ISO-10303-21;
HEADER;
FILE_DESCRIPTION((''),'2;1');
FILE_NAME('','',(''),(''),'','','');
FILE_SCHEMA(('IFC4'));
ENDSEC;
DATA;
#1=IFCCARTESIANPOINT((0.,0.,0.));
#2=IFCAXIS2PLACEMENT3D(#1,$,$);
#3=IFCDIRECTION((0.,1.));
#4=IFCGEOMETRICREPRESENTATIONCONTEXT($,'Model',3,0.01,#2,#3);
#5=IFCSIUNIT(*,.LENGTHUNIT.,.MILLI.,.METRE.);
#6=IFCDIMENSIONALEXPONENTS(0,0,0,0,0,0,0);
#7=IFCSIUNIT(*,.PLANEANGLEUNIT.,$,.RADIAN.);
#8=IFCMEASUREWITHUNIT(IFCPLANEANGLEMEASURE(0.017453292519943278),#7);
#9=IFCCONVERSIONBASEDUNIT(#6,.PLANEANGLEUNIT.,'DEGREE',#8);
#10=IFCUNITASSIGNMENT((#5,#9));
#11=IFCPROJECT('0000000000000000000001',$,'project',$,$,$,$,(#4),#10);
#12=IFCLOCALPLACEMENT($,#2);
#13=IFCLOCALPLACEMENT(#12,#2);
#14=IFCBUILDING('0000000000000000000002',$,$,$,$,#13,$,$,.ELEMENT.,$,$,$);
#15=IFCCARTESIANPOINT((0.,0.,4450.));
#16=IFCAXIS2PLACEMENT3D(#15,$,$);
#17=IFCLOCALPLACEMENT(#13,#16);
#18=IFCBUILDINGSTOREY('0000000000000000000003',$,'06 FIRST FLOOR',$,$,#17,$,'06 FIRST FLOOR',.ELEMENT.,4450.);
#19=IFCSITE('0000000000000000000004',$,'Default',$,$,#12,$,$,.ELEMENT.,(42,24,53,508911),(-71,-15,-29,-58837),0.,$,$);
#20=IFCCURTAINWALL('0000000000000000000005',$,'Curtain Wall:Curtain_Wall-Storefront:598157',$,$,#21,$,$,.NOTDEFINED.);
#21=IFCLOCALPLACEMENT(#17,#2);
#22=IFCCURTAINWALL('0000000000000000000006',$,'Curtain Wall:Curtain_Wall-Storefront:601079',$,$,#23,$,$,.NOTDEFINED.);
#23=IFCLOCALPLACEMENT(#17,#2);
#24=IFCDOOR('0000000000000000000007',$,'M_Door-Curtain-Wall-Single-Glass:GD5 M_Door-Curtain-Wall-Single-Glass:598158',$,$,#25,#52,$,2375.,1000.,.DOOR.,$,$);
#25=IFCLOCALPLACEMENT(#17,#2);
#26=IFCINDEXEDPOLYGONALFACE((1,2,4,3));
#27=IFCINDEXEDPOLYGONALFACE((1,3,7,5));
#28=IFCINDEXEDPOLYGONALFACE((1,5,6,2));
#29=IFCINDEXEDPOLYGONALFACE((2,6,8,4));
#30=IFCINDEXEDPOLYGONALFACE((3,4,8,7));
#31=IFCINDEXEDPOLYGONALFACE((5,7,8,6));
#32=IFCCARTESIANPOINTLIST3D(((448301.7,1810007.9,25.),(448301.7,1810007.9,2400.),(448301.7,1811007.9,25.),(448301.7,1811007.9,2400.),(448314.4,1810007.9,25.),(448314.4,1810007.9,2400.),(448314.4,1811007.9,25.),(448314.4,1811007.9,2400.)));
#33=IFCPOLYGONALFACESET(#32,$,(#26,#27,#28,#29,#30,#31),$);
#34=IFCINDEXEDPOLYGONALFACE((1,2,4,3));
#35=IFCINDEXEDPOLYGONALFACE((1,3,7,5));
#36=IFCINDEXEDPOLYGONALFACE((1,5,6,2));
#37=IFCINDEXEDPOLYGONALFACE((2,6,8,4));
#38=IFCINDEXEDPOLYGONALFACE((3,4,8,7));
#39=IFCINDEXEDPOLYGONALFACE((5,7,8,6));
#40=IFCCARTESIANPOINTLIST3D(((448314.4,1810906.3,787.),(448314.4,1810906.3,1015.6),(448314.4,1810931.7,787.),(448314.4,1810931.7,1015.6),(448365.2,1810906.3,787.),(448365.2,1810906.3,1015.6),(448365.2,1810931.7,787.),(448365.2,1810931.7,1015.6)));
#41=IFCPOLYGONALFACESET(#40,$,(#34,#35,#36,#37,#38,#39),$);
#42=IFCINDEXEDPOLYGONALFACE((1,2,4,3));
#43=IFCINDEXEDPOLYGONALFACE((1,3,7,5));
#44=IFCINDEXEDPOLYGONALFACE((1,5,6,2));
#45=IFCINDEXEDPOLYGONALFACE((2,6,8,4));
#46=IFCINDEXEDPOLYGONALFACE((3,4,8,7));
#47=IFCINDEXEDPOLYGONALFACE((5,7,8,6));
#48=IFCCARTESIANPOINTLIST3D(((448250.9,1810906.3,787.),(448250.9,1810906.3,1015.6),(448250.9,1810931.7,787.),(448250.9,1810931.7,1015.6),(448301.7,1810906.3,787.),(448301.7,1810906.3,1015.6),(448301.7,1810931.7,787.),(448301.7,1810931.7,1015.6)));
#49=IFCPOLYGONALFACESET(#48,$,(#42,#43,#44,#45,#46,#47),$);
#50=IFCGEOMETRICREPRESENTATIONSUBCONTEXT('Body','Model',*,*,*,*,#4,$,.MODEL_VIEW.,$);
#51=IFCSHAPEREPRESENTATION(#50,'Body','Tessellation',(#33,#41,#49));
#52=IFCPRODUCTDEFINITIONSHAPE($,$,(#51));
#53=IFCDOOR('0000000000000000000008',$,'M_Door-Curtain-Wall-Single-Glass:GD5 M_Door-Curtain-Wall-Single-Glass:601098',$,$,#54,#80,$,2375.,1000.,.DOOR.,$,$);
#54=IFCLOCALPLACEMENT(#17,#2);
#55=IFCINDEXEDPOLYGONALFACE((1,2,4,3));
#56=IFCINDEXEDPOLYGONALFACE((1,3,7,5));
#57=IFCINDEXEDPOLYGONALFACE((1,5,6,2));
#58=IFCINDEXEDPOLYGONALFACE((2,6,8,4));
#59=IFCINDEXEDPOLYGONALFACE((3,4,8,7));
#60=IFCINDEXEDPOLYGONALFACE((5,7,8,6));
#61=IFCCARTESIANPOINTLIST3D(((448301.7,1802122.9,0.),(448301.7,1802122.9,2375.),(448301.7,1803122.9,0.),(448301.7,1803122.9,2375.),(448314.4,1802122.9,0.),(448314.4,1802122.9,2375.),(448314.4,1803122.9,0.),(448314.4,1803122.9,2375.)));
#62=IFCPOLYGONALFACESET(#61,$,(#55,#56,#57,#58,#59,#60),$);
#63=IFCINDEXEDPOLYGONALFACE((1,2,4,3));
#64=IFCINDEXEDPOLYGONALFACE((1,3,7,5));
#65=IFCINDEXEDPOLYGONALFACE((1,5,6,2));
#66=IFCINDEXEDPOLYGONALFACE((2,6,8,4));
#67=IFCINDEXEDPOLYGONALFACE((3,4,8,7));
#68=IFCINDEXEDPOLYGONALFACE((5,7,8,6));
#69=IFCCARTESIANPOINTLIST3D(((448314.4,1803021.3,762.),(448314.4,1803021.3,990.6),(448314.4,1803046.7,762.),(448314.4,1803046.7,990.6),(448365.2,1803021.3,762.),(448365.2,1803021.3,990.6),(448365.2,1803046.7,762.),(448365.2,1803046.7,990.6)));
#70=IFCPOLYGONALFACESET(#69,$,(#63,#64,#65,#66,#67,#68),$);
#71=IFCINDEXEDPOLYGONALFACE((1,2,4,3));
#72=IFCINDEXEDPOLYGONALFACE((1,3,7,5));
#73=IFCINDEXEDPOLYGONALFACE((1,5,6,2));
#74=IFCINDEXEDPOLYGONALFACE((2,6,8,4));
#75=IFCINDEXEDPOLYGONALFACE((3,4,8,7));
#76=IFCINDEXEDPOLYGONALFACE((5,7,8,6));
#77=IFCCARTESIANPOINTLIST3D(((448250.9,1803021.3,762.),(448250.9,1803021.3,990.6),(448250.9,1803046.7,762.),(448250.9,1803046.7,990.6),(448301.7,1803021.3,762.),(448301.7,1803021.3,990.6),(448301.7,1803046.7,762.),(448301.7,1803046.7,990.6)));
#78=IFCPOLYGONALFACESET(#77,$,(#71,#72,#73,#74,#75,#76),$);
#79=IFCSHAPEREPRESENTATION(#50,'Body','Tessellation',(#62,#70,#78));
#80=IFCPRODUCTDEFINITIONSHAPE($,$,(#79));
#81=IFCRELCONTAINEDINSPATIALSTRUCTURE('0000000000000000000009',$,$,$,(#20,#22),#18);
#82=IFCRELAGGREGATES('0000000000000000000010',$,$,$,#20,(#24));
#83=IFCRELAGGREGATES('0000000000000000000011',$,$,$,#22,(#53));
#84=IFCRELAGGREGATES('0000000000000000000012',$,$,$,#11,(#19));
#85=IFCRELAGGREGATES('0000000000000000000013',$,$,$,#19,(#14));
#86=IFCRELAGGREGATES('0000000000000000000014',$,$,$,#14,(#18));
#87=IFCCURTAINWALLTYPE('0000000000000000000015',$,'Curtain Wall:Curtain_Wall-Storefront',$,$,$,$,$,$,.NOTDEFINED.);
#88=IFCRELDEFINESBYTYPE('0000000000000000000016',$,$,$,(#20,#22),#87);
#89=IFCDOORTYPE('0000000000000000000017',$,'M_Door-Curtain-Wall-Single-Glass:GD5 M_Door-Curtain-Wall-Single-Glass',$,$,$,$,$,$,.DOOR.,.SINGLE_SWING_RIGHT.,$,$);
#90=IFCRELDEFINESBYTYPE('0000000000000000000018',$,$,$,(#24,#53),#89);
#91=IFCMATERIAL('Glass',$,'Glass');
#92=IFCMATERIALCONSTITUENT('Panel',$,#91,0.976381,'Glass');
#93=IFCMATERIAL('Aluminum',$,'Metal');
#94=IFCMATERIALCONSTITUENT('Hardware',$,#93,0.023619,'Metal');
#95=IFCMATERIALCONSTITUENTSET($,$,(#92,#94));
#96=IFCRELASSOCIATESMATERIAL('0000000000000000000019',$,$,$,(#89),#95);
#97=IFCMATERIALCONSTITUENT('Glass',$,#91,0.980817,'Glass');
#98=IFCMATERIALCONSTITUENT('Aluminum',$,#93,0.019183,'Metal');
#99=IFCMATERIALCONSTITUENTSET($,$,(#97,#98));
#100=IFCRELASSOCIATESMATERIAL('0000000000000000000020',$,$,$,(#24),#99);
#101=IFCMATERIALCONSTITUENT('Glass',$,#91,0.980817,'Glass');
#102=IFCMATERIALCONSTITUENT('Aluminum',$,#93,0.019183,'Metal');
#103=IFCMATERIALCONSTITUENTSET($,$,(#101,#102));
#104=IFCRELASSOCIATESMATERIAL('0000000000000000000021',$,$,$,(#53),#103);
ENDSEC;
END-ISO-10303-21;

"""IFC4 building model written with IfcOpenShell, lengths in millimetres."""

from ifc_helpers import new_model, entity, si_unit, converted_unit, direction, frame, origin, place, context, subcontext, project, spatial, indexed_curve, outline, extrude, source, transform, mapped, material, constituent, constituent_set, type_object, type_shapes, element, aggregate, save


model = new_model("IFC4")

# Units and contexts
model_context = context("Model", 3, precision=0.01, world=origin(), true_north=direction((0.0, 1.0)))
body_context = subcontext(model_context, "Body", "Model", "MODEL_VIEW")
ifc_project = project(units=[si_unit("LENGTHUNIT", "METRE", prefix="MILLI"), converted_unit("PLANEANGLEUNIT", "DEGREE", entity("IfcPlaneAngleMeasure", 0.017453292519943278), si_unit("PLANEANGLEUNIT", "RADIAN"), dimensions=[0, 0, 0, 0, 0, 0, 0])], contexts=[model_context])

# Site, building, storey
site_placement = place(None, origin())
site = spatial("IfcSite", under=ifc_project, at=site_placement, Name="Default", CompositionType="ELEMENT", RefLatitude=(42, 24, 53, 508911), RefLongitude=(-71, -15, -29, -58837), RefElevation=0.0)
building_placement = place(site_placement, origin())
building = spatial("IfcBuilding", under=site, at=building_placement, CompositionType="ELEMENT")
storey_placement = place(building_placement, frame((0.0, 0.0, 4450.0)))
storey = spatial("IfcBuildingStorey", under=building, at=storey_placement, Name="06 FIRST FLOOR", LongName="06 FIRST FLOOR", CompositionType="ELEMENT", Elevation=4450.0)

# Curtain walls
curtain_wall_type = type_object("IfcCurtainWallType", Name="Curtain Wall:Curtain_Wall-Storefront", PredefinedType="NOTDEFINED")
curtain_wall_1_placement = place(storey_placement, frame((0.0, 0.0, -4450.0)))
curtain_wall_1 = element("IfcCurtainWall", 1, at=curtain_wall_1_placement, inside=storey, type_object=curtain_wall_type, Name="Curtain Wall:Curtain_Wall-Storefront:598157", PredefinedType="NOTDEFINED")
curtain_wall_2_placement = place(storey_placement, frame((0.0, 0.0, -4450.0)))
curtain_wall_2 = element("IfcCurtainWall", 2, at=curtain_wall_2_placement, inside=storey, type_object=curtain_wall_type, Name="Curtain Wall:Curtain_Wall-Storefront:601079", PredefinedType="NOTDEFINED")

# Shared definitions
ifc_material_1 = material(Name="Glass", Category="Glass")

# Doors
ifc_constituent_1 = constituent(ifc_material_1, Name="Glass", Category="Glass", fraction=0.980817)
ifc_material_2 = material(Name="Aluminum", Category="Metal")
ifc_constituent_2 = constituent(ifc_material_2, Name="Aluminum", Category="Metal", fraction=0.019183)
ifc_constituent_set_1 = constituent_set(constituents=[ifc_constituent_1, ifc_constituent_2])
ifc_constituent_3 = constituent(ifc_material_1, Name="Panel", Category="Glass", fraction=0.976381)
ifc_constituent_4 = constituent(ifc_material_2, Name="Hardware", Category="Metal", fraction=0.023619)
ifc_constituent_set_2 = constituent_set(constituents=[ifc_constituent_3, ifc_constituent_4])
door_type = type_object("IfcDoorType", Name="M_Door-Curtain-Wall-Single-Glass:GD5 M_Door-Curtain-Wall-Single-Glass", OperationType="SINGLE_SWING_RIGHT", PredefinedType="DOOR", material=ifc_constituent_set_2)
shared_shape_1 = source(origin(), body_context, "Body", "SweptSolid", [
    extrude(outline(indexed_curve([(-500.0, -6.4), (500.0, -6.4), (500.0, 6.4), (-500.0, 6.4), (-500.0, -6.4)], self_intersect=False)), frame((0.0, 44.5, 0.0), z_axis=(0.0, 0.0, 1.0), x_axis=(-1.0, 0.0, 0.0)), (0.0, 0.0, 1.0), 2375.0),
    extrude(outline(indexed_curve([(-25.4, -12.7), (25.4, -12.7), (25.4, 12.7), (-25.4, 12.7), (-25.4, -12.7)], self_intersect=False)), frame((-411.1, 76.2, 762.0), z_axis=(0.0, 0.0, 1.0), x_axis=(0.0, -1.0, 0.0)), (0.0, 0.0, 1.0), 228.6),
    extrude(outline(indexed_curve([(-25.4, -12.7), (25.4, -12.7), (25.4, 12.7), (-25.4, 12.7), (-25.4, -12.7)], self_intersect=False)), frame((-411.1, 12.7, 762.0), z_axis=(0.0, 0.0, 1.0), x_axis=(0.0, 1.0, 0.0)), (0.0, 0.0, 1.0), 228.6),
])
type_shapes(door_type, [shared_shape_1])
door_1_placement = place(curtain_wall_1_placement, frame((448263.6, 1810507.9, 4475.0), z_axis=(0.0, 0.0, 1.0), x_axis=(0.0, -1.0, 0.0)))
door_1 = element("IfcDoor", 3, at=door_1_placement, type_object=door_type, material=ifc_constituent_set_1, Name="M_Door-Curtain-Wall-Single-Glass:GD5 M_Door-Curtain-Wall-Single-Glass:598158", OverallHeight=2375.0, OverallWidth=1000.0, PredefinedType="DOOR", context=body_context, shape_type="MappedRepresentation", body=[
    mapped(shared_shape_1, transform((0.0, 0.0, 0.0), scale=1.0)),
])
aggregate(curtain_wall_1, [door_1])
ifc_constituent_5 = constituent(ifc_material_1, Name="Glass", Category="Glass", fraction=0.980817)
ifc_constituent_6 = constituent(ifc_material_2, Name="Aluminum", Category="Metal", fraction=0.019183)
ifc_constituent_set_3 = constituent_set(constituents=[ifc_constituent_5, ifc_constituent_6])
door_2_placement = place(curtain_wall_2_placement, frame((448263.6, 1802622.9, 4450.0), z_axis=(0.0, 0.0, 1.0), x_axis=(0.0, -1.0, 0.0)))
door_2 = element("IfcDoor", 4, at=door_2_placement, type_object=door_type, material=ifc_constituent_set_3, Name="M_Door-Curtain-Wall-Single-Glass:GD5 M_Door-Curtain-Wall-Single-Glass:601098", OverallHeight=2375.0, OverallWidth=1000.0, PredefinedType="DOOR", context=body_context, shape_type="MappedRepresentation", body=[
    mapped(shared_shape_1, transform((0.0, 0.0, 0.0), scale=1.0)),
])
aggregate(curtain_wall_2, [door_2])

save(model, "model.ifc")
